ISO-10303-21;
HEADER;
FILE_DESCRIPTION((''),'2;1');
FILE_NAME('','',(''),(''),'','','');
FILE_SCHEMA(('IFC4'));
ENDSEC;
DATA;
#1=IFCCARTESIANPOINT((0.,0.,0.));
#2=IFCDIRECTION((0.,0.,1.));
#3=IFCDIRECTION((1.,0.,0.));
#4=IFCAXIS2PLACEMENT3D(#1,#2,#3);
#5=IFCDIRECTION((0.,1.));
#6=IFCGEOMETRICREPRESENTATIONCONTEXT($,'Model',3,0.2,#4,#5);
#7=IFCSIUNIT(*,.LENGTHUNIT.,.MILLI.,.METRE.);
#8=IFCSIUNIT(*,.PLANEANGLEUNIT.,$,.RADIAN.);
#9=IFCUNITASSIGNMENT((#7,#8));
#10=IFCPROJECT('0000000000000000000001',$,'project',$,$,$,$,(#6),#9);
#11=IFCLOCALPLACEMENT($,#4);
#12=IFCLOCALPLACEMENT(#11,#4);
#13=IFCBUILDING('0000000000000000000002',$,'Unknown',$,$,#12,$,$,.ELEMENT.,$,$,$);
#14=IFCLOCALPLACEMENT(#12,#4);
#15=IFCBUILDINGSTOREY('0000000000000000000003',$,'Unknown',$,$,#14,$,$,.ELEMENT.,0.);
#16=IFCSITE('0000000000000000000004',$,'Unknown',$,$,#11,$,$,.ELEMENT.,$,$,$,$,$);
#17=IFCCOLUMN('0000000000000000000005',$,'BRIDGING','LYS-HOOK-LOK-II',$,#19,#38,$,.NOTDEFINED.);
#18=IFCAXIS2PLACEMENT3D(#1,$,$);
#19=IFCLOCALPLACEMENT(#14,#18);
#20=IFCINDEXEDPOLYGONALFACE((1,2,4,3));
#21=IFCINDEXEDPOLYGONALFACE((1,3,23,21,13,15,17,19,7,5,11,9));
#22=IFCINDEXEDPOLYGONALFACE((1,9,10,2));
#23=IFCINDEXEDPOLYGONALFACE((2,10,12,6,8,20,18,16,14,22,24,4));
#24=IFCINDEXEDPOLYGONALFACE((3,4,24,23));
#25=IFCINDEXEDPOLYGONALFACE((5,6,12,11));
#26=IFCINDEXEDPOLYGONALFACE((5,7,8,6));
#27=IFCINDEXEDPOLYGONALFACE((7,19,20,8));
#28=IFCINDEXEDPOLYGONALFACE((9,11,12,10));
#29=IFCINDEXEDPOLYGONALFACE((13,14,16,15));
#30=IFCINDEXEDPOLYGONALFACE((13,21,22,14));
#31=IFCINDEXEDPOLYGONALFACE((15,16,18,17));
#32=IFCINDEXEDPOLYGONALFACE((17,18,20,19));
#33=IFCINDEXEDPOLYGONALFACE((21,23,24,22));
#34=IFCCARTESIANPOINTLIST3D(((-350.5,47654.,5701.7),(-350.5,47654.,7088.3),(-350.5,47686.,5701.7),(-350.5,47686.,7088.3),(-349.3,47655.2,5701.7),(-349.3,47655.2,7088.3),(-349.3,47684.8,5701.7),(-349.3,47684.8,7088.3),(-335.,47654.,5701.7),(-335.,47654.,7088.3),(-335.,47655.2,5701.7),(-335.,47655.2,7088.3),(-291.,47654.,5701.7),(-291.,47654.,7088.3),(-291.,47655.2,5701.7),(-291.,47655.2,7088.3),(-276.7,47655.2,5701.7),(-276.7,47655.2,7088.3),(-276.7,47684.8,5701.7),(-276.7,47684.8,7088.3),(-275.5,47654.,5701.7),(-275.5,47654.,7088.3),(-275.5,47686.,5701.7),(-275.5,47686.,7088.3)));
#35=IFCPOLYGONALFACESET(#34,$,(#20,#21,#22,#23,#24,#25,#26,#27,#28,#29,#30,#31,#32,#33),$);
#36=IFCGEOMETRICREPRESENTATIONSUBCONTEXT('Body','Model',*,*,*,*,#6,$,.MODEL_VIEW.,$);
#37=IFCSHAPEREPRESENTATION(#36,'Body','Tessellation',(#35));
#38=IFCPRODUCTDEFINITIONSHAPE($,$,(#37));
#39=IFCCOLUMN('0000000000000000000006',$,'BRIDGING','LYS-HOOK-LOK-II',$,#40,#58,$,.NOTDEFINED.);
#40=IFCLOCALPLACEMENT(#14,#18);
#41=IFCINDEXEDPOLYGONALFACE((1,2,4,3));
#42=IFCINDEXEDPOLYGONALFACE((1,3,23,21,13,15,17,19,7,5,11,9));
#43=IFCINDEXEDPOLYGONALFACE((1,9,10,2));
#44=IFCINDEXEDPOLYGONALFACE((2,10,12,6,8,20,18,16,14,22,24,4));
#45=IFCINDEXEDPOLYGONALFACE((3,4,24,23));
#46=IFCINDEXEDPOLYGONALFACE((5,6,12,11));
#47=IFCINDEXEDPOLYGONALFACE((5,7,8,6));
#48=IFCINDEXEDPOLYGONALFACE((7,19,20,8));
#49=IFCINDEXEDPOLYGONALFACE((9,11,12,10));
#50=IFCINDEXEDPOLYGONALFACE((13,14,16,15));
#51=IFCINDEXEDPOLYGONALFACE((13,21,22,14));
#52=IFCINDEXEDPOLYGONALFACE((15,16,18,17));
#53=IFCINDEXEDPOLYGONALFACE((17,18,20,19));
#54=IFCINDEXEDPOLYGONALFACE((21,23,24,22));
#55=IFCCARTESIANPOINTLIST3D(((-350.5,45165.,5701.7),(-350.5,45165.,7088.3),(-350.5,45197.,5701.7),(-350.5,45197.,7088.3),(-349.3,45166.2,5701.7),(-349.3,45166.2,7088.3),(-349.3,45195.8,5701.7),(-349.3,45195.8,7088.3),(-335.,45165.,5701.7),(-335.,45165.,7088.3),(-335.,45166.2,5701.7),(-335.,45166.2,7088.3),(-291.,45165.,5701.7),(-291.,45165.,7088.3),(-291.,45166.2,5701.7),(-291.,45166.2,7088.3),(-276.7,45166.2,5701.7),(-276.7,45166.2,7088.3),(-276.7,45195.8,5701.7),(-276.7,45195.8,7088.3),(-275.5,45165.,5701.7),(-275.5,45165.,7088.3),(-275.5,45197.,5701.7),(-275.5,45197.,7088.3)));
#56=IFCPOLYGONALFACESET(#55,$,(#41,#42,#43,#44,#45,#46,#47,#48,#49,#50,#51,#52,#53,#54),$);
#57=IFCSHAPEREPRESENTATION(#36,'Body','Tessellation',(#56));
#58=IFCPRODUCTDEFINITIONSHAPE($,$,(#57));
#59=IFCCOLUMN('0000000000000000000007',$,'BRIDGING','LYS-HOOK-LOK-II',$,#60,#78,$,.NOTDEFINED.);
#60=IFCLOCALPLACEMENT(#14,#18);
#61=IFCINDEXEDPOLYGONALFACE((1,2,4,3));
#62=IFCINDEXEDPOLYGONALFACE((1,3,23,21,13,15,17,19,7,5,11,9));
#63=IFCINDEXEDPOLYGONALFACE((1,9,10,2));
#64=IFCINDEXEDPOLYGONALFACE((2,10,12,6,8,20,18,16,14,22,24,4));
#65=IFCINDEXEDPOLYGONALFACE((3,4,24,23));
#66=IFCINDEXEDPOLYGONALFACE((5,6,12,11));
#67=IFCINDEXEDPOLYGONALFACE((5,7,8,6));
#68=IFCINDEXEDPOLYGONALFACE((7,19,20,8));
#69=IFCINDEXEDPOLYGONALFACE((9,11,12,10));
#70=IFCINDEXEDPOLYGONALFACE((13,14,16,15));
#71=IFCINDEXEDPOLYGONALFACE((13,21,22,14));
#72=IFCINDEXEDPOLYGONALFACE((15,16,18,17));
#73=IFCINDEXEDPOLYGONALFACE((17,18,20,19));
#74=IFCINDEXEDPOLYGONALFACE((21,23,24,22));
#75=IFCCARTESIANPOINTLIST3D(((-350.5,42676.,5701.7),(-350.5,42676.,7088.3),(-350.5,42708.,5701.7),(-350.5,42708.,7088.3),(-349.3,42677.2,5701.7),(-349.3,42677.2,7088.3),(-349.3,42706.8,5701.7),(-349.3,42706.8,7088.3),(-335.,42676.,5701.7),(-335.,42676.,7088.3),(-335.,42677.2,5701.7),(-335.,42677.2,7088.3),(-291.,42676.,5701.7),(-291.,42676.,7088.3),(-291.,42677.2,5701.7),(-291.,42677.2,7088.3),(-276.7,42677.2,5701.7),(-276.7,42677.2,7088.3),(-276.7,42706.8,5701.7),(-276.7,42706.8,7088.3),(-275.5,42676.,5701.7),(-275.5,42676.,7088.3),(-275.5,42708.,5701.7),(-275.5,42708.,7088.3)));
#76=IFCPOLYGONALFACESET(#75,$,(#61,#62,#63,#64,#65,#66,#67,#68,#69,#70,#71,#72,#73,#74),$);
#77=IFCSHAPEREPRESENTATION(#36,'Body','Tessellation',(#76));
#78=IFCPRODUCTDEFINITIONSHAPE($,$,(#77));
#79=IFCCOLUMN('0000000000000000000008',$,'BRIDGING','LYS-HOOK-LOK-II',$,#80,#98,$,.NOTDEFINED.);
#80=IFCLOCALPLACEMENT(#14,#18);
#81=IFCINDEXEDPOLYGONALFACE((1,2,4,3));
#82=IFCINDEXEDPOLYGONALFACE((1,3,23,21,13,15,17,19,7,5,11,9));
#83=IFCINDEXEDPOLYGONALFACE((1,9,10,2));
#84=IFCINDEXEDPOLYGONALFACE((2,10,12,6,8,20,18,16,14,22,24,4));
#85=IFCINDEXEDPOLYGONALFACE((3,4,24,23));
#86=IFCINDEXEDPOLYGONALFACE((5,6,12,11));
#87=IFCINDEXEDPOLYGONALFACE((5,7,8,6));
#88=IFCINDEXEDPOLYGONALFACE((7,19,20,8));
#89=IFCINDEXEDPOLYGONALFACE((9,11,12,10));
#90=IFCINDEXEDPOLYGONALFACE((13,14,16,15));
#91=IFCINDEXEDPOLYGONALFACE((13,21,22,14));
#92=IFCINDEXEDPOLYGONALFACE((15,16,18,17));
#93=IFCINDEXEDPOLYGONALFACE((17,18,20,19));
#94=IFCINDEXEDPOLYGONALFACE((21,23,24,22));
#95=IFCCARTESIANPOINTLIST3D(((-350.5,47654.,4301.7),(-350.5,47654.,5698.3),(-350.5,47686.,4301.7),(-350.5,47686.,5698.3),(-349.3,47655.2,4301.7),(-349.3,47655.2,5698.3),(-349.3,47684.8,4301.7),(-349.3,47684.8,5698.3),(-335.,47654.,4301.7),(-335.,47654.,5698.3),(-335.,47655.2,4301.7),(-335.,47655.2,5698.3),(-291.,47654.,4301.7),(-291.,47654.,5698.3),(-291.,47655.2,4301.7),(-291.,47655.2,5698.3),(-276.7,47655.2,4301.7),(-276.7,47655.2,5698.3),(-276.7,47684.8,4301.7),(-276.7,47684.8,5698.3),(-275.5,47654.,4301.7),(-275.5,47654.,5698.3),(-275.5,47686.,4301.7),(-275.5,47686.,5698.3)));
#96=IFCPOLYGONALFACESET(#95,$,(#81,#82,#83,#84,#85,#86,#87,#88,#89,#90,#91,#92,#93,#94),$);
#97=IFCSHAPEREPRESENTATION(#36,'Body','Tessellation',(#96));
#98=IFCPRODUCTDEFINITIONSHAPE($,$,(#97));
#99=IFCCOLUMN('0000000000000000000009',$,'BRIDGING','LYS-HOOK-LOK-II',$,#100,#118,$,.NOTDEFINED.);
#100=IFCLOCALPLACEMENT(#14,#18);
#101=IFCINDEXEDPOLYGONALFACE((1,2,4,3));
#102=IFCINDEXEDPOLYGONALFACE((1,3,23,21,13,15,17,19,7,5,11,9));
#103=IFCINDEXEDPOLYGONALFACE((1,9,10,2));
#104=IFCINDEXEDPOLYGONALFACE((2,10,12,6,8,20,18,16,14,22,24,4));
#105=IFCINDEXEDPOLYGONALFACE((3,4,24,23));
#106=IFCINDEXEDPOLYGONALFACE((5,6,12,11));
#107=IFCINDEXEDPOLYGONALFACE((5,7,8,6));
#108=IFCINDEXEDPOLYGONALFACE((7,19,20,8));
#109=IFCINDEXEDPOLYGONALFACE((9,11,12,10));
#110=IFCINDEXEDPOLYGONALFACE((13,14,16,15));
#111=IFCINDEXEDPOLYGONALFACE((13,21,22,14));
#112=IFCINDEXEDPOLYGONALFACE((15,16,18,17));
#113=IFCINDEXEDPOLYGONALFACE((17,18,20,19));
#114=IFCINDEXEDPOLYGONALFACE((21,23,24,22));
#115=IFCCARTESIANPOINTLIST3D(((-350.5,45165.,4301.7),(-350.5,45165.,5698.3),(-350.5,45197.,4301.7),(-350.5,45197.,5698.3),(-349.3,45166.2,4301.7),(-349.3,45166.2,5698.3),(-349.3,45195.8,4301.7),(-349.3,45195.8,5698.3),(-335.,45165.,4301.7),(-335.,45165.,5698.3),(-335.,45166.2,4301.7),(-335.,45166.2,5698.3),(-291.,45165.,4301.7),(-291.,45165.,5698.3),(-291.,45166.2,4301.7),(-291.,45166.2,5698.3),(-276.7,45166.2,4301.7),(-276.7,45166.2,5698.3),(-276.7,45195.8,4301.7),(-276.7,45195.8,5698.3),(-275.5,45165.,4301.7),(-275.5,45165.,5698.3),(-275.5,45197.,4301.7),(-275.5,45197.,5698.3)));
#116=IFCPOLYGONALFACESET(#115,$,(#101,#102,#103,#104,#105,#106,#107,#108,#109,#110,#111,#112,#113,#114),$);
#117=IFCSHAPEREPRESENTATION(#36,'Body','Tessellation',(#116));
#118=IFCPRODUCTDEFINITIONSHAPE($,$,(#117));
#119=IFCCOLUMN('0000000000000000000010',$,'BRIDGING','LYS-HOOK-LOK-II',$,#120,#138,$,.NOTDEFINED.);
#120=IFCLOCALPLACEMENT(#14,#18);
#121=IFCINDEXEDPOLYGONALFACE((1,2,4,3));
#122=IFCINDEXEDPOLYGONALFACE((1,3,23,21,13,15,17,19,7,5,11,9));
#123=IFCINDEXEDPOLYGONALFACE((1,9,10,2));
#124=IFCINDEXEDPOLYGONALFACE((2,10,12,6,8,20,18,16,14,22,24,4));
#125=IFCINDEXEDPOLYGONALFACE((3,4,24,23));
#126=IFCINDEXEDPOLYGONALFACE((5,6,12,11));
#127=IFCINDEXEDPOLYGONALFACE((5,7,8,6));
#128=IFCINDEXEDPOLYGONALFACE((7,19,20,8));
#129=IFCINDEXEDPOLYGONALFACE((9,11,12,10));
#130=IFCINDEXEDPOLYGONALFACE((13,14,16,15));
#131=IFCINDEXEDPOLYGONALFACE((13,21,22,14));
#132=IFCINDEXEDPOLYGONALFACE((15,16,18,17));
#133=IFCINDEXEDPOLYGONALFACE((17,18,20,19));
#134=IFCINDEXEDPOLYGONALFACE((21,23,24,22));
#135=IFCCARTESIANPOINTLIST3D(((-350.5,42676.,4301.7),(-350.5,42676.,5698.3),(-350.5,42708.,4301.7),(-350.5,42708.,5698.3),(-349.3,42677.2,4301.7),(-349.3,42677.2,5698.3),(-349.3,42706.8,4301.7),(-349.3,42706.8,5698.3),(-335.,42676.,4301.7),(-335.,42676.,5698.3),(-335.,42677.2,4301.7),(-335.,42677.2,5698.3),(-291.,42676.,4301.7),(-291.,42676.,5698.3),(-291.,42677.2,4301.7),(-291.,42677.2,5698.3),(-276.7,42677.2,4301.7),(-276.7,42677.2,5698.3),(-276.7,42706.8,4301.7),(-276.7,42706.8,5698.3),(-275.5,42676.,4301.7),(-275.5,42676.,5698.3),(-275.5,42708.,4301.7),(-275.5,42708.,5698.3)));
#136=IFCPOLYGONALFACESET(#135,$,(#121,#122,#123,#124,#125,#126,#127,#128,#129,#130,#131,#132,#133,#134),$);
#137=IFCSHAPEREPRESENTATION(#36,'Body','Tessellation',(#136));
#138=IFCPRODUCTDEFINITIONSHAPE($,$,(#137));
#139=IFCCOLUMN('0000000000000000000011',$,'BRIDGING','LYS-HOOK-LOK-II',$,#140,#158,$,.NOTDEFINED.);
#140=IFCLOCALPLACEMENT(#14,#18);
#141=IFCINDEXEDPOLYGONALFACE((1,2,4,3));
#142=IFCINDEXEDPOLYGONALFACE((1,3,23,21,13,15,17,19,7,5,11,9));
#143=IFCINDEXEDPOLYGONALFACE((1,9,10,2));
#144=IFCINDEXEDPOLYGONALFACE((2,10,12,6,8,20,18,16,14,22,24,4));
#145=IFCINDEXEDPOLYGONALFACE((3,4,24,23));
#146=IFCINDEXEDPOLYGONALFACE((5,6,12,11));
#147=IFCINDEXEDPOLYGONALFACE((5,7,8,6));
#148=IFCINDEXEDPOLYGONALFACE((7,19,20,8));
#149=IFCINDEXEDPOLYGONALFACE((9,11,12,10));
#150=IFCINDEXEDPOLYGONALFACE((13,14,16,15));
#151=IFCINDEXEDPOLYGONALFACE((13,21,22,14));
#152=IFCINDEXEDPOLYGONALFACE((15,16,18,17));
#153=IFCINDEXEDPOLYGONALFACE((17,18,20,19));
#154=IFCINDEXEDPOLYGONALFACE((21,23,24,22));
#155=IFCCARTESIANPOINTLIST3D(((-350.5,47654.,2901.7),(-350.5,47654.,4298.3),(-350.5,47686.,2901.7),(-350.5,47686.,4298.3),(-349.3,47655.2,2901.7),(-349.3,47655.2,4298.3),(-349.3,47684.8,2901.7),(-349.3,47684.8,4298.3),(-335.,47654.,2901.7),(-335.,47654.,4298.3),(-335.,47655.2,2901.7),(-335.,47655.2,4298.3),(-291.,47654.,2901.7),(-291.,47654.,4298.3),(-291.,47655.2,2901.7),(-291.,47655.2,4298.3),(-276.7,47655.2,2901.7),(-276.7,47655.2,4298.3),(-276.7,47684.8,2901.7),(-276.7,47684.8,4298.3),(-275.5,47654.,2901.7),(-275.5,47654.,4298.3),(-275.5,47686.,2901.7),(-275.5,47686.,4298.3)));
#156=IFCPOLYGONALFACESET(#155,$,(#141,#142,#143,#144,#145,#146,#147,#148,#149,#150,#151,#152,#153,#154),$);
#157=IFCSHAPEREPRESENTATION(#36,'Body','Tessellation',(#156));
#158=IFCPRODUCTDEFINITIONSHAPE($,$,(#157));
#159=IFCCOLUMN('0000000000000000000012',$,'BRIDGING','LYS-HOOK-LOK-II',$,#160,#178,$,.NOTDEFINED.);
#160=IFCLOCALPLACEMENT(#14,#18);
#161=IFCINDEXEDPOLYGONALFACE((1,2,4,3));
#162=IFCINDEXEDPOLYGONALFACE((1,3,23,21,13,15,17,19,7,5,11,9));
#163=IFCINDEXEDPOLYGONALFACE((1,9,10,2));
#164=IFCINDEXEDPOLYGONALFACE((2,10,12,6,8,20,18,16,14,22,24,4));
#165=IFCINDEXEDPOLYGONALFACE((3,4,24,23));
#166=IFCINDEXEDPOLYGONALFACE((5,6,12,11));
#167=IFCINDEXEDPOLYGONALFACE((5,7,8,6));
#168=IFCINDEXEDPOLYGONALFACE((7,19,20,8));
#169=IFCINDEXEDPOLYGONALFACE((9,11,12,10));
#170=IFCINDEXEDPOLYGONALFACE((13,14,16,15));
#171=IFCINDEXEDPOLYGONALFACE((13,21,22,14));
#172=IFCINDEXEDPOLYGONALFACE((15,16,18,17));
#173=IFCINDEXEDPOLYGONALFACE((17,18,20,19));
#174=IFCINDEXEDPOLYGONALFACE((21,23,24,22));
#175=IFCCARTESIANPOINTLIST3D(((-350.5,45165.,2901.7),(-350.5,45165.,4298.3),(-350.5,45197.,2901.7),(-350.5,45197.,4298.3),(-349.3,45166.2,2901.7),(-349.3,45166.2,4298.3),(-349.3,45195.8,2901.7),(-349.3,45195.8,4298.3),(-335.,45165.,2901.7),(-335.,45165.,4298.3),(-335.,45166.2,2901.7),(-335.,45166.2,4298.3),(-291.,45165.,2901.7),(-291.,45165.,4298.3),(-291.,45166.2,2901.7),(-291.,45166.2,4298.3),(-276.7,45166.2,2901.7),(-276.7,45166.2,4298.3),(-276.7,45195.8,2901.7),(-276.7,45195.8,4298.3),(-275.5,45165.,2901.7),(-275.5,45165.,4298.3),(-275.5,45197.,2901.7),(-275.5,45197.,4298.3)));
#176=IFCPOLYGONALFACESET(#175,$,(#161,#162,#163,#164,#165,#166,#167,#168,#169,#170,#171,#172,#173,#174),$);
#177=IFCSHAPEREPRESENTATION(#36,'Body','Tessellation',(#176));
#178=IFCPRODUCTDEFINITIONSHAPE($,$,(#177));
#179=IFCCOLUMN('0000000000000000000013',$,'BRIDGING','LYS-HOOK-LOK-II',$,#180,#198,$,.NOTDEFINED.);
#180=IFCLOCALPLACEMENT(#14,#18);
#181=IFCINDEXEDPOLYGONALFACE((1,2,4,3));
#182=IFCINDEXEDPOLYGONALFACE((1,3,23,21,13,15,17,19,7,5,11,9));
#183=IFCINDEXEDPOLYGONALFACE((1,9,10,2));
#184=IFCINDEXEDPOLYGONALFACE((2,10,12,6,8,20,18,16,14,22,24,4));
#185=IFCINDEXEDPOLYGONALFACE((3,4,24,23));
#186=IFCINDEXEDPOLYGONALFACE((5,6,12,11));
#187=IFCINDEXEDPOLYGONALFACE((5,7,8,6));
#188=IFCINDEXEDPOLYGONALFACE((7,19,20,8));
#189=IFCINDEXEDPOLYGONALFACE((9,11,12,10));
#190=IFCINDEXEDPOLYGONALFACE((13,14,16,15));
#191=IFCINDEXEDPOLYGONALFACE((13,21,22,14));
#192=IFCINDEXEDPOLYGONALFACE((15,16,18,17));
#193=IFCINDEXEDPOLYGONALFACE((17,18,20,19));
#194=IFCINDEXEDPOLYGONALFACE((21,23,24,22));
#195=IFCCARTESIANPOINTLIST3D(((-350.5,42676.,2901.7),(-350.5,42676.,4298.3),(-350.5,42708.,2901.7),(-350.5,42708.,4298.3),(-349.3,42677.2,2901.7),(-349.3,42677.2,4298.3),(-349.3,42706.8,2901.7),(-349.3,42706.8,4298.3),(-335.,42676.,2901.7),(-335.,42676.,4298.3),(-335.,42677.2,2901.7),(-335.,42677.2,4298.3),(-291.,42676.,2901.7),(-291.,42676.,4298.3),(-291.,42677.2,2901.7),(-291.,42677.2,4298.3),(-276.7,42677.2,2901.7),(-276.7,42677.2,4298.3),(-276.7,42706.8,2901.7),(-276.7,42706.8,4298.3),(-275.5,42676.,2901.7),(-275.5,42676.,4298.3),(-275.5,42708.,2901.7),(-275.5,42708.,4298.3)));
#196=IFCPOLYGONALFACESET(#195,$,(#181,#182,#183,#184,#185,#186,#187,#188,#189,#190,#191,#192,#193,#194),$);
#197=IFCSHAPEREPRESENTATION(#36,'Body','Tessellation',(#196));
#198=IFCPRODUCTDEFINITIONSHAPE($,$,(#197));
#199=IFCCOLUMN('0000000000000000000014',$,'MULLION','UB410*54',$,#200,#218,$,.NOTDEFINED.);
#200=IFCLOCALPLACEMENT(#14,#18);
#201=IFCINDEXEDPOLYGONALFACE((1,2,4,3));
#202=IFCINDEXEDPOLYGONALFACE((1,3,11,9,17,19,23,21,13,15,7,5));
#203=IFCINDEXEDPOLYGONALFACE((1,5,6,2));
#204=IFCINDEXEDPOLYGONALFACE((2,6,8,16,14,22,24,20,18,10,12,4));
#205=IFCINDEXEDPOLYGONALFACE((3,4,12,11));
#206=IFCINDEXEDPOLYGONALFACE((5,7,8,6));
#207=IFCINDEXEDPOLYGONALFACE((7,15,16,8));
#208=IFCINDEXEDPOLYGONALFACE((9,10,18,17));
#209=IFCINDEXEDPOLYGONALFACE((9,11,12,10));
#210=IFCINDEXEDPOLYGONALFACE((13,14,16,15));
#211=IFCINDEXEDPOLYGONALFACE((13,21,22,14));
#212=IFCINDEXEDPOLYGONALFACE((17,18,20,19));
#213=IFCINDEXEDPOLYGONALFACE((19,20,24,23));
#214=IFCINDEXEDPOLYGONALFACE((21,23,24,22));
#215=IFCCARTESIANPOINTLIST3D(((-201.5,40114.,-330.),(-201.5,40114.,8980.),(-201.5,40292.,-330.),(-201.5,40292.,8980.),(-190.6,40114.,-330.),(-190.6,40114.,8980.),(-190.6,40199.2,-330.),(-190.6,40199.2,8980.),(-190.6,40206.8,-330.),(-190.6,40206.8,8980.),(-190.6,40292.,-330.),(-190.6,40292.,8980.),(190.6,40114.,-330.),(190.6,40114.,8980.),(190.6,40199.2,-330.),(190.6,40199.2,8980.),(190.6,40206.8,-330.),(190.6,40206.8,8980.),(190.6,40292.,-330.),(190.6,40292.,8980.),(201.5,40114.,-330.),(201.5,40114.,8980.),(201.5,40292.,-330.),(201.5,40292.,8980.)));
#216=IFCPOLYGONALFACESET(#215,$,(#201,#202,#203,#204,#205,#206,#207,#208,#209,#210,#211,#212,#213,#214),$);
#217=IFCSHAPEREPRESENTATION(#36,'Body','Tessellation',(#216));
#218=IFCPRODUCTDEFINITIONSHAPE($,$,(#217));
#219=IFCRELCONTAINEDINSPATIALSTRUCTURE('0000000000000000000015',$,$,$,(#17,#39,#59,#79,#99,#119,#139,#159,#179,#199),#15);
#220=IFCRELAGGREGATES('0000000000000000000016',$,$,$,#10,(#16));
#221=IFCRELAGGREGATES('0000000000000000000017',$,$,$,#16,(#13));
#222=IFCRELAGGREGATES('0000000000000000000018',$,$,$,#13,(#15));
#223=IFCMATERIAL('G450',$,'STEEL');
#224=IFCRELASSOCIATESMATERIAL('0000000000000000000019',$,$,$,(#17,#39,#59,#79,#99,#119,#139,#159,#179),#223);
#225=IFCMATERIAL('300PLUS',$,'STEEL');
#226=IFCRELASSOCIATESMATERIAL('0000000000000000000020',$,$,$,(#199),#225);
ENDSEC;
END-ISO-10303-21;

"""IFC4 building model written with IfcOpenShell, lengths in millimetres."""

from ifc_helpers import new_model, si_unit, direction, frame, origin_with_axes, place, context, subcontext, project, spatial, line, indexed_curve, outline, extrude, material, element, save


model = new_model("IFC4")

# Units and contexts
model_context = context("Model", 3, precision=0.2, world=origin_with_axes(), true_north=direction((0.0, 1.0)))
body_context = subcontext(model_context, "Body", "Model", "MODEL_VIEW")
ifc_project = project(units=[si_unit("LENGTHUNIT", "METRE", prefix="MILLI"), si_unit("PLANEANGLEUNIT", "RADIAN")], contexts=[model_context])

# Site, building, storey
site_placement = place(None, origin_with_axes())
site = spatial("IfcSite", under=ifc_project, at=site_placement, Name="Unknown", CompositionType="ELEMENT")
building_placement = place(site_placement, origin_with_axes())
building = spatial("IfcBuilding", under=site, at=building_placement, Name="Unknown", CompositionType="ELEMENT")
storey_placement = place(building_placement, origin_with_axes())
storey = spatial("IfcBuildingStorey", under=building, at=storey_placement, Name="Unknown", CompositionType="ELEMENT", Elevation=0.0)

# Columns
ifc_material_1 = material(Name="G450", Category="STEEL")
for number, where, z_axis, x_axis, name in (
    (1, (-313.0, 47670.0, 5701.7), (0.0, -1.0, 0.0), (0.0, 0.0, 1.0), "BRIDGING"),
    (2, (-313.0, 45181.0, 5701.7), (0.0, -1.0, 0.0), (0.0, 0.0, 1.0), "BRIDGING"),
    (3, (-313.0, 42692.0, 5701.7), (0.0, -1.0, 0.0), (0.0, 0.0, 1.0), "BRIDGING"),
):
    element("IfcColumn", number, at=place(storey_placement, frame(where, z_axis=z_axis, x_axis=x_axis)), inside=storey, material=ifc_material_1, Name=name, Description="LYS-HOOK-LOK-II", PredefinedType="NOTDEFINED", context=body_context, shape_type="SolidModel", body=[
        extrude(outline(indexed_curve([(16.0, -37.5), (16.0, -22.0), (14.8, -22.0), (14.8, -36.3), (-14.8, -36.3), (-14.8, 36.3), (14.8, 36.3), (14.8, 22.0), (16.0, 22.0), (16.0, 37.5), (-16.0, 37.5), (-16.0, -37.5)], segments=[line(1, 2, 3, 4, 5, 6, 7, 8, 9, 10, 11, 12, 1)])), frame((0.0, 0.0, 0.0), z_axis=(-1.0, 0.0, 0.0), x_axis=(0.0, 0.0, 1.0)), (0.0, 0.0, -1.0), 1386.6),
    ])
for number, where, z_axis, x_axis, name in (
    (4, (-313.0, 47670.0, 4301.7), (0.0, -1.0, 0.0), (0.0, 0.0, 1.0), "BRIDGING"),
    (5, (-313.0, 45181.0, 4301.7), (0.0, -1.0, 0.0), (0.0, 0.0, 1.0), "BRIDGING"),
    (6, (-313.0, 42692.0, 4301.7), (0.0, -1.0, 0.0), (0.0, 0.0, 1.0), "BRIDGING"),
    (7, (-313.0, 47670.0, 2901.7), (0.0, -1.0, 0.0), (0.0, 0.0, 1.0), "BRIDGING"),
    (8, (-313.0, 45181.0, 2901.7), (0.0, -1.0, 0.0), (0.0, 0.0, 1.0), "BRIDGING"),
    (9, (-313.0, 42692.0, 2901.7), (0.0, -1.0, 0.0), (0.0, 0.0, 1.0), "BRIDGING"),
):
    element("IfcColumn", number, at=place(storey_placement, frame(where, z_axis=z_axis, x_axis=x_axis)), inside=storey, material=ifc_material_1, Name=name, Description="LYS-HOOK-LOK-II", PredefinedType="NOTDEFINED", context=body_context, shape_type="SolidModel", body=[
        extrude(outline(indexed_curve([(16.0, -37.5), (16.0, -22.0), (14.8, -22.0), (14.8, -36.3), (-14.8, -36.3), (-14.8, 36.3), (14.8, 36.3), (14.8, 22.0), (16.0, 22.0), (16.0, 37.5), (-16.0, 37.5), (-16.0, -37.5)], segments=[line(1, 2, 3, 4, 5, 6, 7, 8, 9, 10, 11, 12, 1)])), frame((0.0, 0.0, 0.0), z_axis=(-1.0, 0.0, 0.0), x_axis=(0.0, 0.0, 1.0)), (0.0, 0.0, -1.0), 1396.6),
    ])
ifc_material_2 = material(Name="300PLUS", Category="STEEL")
column_placement = place(storey_placement, frame((0.0, 40203.0, -330.0), z_axis=(0.0, -1.0, 0.0), x_axis=(0.0, 0.0, 1.0)))
element("IfcColumn", 10, at=column_placement, inside=storey, material=ifc_material_2, Name="MULLION", Description="UB410*54", PredefinedType="NOTDEFINED", context=body_context, shape_type="SolidModel", body=[
    extrude(outline(indexed_curve([(-89.0, -201.5), (89.0, -201.5), (89.0, -190.6), (3.8, -190.6), (3.8, 190.6), (89.0, 190.6), (89.0, 201.5), (-89.0, 201.5), (-89.0, 190.6), (-3.8, 190.6), (-3.8, -190.6), (-89.0, -190.6)], segments=[line(1, 2, 3, 4, 5, 6, 7, 8, 9, 10, 11, 12, 1)])), frame((0.0, 0.0, 0.0), z_axis=(-1.0, 0.0, 0.0), x_axis=(0.0, 0.0, 1.0)), (0.0, 0.0, -1.0), 9310.0),
])

save(model, "model.ifc")
